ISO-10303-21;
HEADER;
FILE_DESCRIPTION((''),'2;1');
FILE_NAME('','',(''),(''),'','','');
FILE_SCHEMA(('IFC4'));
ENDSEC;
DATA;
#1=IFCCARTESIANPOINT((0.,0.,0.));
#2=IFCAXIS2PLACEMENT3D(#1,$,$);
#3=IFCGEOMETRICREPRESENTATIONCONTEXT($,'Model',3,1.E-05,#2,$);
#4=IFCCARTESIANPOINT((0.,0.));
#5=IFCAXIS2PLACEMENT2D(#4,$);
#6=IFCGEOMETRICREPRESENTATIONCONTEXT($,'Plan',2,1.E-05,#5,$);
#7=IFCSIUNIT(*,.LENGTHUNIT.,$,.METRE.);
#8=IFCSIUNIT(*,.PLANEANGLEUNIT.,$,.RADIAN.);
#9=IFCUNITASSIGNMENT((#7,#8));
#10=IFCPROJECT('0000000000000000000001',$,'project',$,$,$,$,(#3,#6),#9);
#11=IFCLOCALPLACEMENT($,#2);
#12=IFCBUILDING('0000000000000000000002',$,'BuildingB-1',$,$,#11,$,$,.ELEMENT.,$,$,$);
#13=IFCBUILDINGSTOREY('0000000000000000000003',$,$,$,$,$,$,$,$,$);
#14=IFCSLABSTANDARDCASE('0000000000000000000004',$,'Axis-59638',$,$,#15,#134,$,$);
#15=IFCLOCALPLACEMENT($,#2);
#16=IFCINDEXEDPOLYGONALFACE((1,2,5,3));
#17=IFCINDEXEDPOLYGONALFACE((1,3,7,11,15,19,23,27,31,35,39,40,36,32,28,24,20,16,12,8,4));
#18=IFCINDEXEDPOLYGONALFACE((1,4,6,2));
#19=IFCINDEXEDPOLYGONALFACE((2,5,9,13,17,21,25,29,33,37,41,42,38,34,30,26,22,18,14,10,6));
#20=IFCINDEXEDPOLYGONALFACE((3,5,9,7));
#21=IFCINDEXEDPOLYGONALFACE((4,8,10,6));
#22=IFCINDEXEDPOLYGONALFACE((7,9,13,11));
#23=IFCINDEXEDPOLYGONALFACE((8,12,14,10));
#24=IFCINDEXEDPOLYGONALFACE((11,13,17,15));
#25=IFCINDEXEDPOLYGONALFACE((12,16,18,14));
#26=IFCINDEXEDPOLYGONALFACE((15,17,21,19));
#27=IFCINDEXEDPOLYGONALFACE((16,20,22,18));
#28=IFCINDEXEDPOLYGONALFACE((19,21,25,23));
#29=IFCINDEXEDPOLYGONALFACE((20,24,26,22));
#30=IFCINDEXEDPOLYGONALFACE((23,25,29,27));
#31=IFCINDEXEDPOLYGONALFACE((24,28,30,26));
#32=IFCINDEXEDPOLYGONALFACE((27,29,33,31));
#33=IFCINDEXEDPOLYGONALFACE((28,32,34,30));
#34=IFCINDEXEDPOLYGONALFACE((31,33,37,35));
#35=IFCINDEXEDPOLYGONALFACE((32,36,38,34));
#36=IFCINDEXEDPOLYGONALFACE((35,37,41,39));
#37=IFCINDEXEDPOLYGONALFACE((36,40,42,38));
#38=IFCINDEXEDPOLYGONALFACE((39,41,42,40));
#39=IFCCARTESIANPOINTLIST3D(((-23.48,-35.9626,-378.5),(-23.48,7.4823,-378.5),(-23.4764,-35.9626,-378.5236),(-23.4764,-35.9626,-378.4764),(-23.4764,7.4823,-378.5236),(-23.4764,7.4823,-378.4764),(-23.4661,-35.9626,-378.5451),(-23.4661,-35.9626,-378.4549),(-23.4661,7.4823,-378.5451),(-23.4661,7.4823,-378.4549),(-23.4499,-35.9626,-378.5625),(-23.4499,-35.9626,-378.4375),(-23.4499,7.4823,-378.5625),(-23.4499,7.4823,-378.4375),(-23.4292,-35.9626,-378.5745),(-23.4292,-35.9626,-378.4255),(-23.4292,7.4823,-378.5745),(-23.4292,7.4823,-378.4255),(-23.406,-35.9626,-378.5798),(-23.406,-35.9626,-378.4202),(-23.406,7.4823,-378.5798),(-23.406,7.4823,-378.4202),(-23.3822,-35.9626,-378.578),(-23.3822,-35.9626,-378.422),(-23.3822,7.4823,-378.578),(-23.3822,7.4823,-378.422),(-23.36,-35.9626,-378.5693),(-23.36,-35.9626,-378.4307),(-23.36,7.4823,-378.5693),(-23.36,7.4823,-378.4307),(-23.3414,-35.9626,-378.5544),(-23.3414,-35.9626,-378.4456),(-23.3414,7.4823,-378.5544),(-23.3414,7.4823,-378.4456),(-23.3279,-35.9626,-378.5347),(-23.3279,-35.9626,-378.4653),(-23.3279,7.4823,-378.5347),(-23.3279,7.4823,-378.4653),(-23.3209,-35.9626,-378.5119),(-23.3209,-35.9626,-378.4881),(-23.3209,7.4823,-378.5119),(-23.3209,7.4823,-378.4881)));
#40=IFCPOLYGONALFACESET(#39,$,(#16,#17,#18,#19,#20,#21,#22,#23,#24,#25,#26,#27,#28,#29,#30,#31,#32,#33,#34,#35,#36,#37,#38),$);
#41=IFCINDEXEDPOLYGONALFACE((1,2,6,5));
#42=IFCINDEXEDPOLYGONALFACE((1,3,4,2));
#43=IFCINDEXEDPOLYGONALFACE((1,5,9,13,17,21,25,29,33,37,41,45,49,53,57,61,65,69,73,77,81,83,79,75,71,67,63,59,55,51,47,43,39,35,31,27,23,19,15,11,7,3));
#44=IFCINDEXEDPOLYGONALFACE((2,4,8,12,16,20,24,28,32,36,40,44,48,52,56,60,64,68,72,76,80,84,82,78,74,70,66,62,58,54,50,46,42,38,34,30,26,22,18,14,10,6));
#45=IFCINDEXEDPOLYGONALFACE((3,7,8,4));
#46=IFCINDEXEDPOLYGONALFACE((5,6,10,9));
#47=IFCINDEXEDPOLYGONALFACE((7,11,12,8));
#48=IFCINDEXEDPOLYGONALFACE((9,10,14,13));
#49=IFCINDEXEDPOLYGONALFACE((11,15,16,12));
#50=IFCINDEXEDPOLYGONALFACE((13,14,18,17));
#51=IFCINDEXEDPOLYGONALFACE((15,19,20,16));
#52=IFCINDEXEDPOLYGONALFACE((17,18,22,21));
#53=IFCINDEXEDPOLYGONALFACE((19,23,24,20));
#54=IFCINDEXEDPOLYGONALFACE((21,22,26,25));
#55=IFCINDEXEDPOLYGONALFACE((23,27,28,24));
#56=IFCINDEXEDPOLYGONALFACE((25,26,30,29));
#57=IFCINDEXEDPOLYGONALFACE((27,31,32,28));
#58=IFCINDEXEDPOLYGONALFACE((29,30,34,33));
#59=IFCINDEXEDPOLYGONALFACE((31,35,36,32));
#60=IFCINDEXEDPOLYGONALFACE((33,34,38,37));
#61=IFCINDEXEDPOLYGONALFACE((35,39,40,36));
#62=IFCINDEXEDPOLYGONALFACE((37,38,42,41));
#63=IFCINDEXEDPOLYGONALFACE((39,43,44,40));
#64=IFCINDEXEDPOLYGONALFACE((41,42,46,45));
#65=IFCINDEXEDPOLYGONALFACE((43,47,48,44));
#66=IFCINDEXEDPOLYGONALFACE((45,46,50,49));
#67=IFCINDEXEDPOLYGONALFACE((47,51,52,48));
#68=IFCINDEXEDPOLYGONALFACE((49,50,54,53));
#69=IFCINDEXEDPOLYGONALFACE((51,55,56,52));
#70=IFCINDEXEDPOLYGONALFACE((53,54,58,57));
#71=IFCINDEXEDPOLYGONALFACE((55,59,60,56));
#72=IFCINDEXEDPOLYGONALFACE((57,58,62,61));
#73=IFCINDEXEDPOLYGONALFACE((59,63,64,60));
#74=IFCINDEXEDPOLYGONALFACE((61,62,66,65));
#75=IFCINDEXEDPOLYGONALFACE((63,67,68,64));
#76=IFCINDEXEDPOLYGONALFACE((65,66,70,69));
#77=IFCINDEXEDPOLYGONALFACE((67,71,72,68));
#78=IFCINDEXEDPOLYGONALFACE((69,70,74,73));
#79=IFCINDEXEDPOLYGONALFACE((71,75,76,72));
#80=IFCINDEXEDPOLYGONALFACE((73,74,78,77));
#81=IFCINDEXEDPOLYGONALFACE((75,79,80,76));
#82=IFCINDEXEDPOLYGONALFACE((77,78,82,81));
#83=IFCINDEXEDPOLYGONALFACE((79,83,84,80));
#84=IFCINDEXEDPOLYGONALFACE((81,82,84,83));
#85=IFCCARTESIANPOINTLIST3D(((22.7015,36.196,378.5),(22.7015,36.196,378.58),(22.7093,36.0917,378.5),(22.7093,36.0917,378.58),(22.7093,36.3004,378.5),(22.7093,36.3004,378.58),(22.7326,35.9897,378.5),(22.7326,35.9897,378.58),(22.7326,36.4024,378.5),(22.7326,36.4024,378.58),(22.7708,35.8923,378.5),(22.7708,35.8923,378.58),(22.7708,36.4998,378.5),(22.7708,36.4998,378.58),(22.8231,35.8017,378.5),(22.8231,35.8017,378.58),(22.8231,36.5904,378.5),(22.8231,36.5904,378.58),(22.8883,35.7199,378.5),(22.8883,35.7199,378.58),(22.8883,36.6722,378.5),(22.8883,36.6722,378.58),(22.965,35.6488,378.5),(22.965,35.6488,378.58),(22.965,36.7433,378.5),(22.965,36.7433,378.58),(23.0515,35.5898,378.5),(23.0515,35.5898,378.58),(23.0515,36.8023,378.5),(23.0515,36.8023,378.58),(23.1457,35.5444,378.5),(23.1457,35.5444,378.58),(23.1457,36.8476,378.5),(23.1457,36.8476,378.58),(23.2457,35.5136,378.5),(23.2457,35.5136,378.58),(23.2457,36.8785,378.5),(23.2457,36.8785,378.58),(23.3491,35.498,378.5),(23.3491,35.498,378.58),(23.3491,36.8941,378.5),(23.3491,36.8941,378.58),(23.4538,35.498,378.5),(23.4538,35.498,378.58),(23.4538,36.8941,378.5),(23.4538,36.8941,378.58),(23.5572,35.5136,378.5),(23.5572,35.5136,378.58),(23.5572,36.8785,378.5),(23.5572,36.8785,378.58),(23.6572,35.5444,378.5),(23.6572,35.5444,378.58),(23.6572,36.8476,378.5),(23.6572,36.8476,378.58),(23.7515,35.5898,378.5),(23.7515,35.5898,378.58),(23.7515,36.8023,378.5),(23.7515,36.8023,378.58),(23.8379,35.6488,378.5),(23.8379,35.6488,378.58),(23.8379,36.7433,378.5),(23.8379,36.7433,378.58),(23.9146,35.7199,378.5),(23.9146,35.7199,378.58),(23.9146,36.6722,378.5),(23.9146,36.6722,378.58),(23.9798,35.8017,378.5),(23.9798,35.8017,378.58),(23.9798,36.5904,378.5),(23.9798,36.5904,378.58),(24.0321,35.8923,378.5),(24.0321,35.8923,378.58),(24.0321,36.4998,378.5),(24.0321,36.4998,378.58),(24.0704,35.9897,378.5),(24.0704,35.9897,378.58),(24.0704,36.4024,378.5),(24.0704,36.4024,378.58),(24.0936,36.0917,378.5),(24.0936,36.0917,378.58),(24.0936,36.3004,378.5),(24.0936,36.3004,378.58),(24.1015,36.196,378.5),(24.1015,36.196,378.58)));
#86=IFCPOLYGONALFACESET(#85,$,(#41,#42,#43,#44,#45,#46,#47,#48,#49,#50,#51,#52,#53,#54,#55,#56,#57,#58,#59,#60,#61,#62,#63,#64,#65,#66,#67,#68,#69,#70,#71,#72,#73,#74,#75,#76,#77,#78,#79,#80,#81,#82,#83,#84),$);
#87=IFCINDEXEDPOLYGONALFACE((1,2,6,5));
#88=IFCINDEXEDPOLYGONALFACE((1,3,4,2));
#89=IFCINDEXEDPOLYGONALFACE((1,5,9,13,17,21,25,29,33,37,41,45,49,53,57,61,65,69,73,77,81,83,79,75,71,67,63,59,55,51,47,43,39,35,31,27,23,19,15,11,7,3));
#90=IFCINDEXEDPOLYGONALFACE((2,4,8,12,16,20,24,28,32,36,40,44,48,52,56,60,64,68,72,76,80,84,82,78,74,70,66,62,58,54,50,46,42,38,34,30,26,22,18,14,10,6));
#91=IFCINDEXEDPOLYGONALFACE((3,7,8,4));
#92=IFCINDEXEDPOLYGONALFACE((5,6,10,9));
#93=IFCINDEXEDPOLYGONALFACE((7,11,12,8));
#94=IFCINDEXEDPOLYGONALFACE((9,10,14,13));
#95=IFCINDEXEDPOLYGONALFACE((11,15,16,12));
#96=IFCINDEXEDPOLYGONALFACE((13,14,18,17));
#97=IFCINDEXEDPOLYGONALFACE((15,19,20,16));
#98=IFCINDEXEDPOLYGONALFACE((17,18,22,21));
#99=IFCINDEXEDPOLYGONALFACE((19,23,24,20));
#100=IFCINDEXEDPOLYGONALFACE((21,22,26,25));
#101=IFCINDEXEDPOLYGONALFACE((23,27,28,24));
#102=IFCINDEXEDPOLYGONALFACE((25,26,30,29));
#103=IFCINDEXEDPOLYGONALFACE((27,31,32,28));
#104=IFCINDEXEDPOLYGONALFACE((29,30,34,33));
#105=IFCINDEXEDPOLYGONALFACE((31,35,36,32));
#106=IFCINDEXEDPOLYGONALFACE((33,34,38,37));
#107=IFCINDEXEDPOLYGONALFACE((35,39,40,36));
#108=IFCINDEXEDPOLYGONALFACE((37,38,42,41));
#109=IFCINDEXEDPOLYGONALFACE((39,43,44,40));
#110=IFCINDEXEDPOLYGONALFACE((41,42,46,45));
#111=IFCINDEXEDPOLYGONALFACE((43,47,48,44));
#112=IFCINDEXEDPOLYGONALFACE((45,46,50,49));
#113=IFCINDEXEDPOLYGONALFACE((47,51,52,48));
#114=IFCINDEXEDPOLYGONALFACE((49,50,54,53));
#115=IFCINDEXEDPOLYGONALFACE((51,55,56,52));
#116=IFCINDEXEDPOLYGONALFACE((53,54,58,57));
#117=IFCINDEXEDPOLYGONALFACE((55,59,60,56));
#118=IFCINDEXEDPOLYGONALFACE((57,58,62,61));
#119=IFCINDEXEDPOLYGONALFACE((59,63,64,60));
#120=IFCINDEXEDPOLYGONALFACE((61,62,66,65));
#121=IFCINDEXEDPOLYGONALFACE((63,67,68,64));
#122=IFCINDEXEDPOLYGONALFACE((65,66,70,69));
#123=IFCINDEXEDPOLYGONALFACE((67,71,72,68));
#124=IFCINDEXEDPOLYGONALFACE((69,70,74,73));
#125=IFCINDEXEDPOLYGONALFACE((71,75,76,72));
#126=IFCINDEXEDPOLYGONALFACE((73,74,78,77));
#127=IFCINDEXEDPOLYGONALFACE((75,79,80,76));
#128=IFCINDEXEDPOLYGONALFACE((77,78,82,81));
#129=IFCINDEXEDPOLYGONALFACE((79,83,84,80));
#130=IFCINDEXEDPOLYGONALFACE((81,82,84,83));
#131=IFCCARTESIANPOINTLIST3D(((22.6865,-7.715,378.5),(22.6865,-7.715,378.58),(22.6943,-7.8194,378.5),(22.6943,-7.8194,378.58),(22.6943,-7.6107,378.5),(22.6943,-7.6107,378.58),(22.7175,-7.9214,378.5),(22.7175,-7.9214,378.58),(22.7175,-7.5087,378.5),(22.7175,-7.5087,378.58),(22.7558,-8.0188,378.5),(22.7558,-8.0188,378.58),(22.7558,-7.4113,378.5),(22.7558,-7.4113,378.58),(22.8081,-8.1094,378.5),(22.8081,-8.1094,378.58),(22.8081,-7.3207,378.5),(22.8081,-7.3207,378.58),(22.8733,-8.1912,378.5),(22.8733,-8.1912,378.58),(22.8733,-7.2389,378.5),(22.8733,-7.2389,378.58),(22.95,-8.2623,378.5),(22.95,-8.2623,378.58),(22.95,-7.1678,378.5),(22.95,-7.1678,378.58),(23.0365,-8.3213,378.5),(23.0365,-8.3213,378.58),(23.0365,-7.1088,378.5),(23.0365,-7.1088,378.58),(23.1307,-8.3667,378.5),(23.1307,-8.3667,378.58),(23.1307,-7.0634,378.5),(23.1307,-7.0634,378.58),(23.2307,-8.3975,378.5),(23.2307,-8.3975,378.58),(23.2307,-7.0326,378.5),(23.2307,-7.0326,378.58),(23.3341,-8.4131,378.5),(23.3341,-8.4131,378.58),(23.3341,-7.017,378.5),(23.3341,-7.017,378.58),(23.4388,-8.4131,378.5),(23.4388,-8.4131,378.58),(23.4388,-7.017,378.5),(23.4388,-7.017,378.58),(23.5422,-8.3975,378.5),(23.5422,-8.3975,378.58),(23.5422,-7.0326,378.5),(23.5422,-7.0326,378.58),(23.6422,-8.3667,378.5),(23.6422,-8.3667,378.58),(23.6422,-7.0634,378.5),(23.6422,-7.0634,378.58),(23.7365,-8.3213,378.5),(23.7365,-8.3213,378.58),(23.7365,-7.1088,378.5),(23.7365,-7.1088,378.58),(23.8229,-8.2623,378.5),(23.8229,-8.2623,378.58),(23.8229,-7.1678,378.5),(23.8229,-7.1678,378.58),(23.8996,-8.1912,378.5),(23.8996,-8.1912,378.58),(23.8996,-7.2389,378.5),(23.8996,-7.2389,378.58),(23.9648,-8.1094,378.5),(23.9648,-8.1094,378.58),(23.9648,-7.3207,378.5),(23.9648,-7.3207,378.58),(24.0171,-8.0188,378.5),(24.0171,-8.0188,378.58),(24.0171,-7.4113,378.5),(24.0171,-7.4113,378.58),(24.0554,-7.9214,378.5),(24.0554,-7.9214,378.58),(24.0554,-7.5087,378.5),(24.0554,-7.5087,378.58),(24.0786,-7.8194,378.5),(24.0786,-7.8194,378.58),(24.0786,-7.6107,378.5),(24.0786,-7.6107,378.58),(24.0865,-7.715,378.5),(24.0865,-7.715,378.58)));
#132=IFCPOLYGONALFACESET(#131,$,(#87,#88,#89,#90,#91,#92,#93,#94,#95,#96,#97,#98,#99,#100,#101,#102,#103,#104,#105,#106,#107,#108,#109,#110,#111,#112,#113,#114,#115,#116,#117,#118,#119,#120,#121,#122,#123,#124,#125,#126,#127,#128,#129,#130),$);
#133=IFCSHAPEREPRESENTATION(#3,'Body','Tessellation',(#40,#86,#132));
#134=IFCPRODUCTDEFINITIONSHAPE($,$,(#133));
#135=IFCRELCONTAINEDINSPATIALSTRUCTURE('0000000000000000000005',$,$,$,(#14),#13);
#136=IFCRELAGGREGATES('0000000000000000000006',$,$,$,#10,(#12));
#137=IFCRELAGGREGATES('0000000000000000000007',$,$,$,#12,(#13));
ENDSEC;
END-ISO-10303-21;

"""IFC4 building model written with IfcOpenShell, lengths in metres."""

from ifc_helpers import new_model, entity, si_unit, frame, origin, origin_2d, place, context, project, spatial, circle, extrude, element, save


model = new_model("IFC4")

# Units and contexts
model_context = context("Model", 3, precision=1e-05, world=origin())
plan_context = context("Plan", 2, precision=1e-05, world=origin_2d())
ifc_project = project(units=[si_unit("LENGTHUNIT", "METRE"), si_unit("PLANEANGLEUNIT", "RADIAN")], contexts=[model_context, plan_context])

# Building, storey
building_placement = place(None, origin())
building = spatial("IfcBuilding", under=ifc_project, at=building_placement, Name="BuildingB-1", CompositionType="ELEMENT")
storey = spatial("IfcBuildingStorey", under=building)

# Slab
element("IfcSlabStandardCase", 1, inside=storey, Name="Axis-59638", context=model_context, shape_type="AdvancedSweptSolid", body=[
    entity("IfcSurfaceCurveSweptAreaSolid", entity("IfcCircleProfileDef", "AREA", None, None, 0.08), None, entity("IfcPolyline", [entity("IfcCartesianPoint", [23.4, 35.9626, 378.5]), entity("IfcCartesianPoint", [23.4, -7.4823, 378.5])]), None, None, entity("IfcPlane", entity("IfcAxis2Placement3D", entity("IfcCartesianPoint", [23.4, 35.9626, 378.5]), entity("IfcDirection", [0.0, 0.0, 1.0]), entity("IfcDirection", [1.0, 0.0, 0.0])))),
    extrude(circle(Radius=0.7), frame((23.4015, 36.196, 378.5)), (0.0, 0.0, 1.0), 0.08),
    extrude(circle(Radius=0.7), frame((23.3865, -7.715, 378.5)), (0.0, 0.0, 1.0), 0.08),
])

save(model, "model.ifc")
